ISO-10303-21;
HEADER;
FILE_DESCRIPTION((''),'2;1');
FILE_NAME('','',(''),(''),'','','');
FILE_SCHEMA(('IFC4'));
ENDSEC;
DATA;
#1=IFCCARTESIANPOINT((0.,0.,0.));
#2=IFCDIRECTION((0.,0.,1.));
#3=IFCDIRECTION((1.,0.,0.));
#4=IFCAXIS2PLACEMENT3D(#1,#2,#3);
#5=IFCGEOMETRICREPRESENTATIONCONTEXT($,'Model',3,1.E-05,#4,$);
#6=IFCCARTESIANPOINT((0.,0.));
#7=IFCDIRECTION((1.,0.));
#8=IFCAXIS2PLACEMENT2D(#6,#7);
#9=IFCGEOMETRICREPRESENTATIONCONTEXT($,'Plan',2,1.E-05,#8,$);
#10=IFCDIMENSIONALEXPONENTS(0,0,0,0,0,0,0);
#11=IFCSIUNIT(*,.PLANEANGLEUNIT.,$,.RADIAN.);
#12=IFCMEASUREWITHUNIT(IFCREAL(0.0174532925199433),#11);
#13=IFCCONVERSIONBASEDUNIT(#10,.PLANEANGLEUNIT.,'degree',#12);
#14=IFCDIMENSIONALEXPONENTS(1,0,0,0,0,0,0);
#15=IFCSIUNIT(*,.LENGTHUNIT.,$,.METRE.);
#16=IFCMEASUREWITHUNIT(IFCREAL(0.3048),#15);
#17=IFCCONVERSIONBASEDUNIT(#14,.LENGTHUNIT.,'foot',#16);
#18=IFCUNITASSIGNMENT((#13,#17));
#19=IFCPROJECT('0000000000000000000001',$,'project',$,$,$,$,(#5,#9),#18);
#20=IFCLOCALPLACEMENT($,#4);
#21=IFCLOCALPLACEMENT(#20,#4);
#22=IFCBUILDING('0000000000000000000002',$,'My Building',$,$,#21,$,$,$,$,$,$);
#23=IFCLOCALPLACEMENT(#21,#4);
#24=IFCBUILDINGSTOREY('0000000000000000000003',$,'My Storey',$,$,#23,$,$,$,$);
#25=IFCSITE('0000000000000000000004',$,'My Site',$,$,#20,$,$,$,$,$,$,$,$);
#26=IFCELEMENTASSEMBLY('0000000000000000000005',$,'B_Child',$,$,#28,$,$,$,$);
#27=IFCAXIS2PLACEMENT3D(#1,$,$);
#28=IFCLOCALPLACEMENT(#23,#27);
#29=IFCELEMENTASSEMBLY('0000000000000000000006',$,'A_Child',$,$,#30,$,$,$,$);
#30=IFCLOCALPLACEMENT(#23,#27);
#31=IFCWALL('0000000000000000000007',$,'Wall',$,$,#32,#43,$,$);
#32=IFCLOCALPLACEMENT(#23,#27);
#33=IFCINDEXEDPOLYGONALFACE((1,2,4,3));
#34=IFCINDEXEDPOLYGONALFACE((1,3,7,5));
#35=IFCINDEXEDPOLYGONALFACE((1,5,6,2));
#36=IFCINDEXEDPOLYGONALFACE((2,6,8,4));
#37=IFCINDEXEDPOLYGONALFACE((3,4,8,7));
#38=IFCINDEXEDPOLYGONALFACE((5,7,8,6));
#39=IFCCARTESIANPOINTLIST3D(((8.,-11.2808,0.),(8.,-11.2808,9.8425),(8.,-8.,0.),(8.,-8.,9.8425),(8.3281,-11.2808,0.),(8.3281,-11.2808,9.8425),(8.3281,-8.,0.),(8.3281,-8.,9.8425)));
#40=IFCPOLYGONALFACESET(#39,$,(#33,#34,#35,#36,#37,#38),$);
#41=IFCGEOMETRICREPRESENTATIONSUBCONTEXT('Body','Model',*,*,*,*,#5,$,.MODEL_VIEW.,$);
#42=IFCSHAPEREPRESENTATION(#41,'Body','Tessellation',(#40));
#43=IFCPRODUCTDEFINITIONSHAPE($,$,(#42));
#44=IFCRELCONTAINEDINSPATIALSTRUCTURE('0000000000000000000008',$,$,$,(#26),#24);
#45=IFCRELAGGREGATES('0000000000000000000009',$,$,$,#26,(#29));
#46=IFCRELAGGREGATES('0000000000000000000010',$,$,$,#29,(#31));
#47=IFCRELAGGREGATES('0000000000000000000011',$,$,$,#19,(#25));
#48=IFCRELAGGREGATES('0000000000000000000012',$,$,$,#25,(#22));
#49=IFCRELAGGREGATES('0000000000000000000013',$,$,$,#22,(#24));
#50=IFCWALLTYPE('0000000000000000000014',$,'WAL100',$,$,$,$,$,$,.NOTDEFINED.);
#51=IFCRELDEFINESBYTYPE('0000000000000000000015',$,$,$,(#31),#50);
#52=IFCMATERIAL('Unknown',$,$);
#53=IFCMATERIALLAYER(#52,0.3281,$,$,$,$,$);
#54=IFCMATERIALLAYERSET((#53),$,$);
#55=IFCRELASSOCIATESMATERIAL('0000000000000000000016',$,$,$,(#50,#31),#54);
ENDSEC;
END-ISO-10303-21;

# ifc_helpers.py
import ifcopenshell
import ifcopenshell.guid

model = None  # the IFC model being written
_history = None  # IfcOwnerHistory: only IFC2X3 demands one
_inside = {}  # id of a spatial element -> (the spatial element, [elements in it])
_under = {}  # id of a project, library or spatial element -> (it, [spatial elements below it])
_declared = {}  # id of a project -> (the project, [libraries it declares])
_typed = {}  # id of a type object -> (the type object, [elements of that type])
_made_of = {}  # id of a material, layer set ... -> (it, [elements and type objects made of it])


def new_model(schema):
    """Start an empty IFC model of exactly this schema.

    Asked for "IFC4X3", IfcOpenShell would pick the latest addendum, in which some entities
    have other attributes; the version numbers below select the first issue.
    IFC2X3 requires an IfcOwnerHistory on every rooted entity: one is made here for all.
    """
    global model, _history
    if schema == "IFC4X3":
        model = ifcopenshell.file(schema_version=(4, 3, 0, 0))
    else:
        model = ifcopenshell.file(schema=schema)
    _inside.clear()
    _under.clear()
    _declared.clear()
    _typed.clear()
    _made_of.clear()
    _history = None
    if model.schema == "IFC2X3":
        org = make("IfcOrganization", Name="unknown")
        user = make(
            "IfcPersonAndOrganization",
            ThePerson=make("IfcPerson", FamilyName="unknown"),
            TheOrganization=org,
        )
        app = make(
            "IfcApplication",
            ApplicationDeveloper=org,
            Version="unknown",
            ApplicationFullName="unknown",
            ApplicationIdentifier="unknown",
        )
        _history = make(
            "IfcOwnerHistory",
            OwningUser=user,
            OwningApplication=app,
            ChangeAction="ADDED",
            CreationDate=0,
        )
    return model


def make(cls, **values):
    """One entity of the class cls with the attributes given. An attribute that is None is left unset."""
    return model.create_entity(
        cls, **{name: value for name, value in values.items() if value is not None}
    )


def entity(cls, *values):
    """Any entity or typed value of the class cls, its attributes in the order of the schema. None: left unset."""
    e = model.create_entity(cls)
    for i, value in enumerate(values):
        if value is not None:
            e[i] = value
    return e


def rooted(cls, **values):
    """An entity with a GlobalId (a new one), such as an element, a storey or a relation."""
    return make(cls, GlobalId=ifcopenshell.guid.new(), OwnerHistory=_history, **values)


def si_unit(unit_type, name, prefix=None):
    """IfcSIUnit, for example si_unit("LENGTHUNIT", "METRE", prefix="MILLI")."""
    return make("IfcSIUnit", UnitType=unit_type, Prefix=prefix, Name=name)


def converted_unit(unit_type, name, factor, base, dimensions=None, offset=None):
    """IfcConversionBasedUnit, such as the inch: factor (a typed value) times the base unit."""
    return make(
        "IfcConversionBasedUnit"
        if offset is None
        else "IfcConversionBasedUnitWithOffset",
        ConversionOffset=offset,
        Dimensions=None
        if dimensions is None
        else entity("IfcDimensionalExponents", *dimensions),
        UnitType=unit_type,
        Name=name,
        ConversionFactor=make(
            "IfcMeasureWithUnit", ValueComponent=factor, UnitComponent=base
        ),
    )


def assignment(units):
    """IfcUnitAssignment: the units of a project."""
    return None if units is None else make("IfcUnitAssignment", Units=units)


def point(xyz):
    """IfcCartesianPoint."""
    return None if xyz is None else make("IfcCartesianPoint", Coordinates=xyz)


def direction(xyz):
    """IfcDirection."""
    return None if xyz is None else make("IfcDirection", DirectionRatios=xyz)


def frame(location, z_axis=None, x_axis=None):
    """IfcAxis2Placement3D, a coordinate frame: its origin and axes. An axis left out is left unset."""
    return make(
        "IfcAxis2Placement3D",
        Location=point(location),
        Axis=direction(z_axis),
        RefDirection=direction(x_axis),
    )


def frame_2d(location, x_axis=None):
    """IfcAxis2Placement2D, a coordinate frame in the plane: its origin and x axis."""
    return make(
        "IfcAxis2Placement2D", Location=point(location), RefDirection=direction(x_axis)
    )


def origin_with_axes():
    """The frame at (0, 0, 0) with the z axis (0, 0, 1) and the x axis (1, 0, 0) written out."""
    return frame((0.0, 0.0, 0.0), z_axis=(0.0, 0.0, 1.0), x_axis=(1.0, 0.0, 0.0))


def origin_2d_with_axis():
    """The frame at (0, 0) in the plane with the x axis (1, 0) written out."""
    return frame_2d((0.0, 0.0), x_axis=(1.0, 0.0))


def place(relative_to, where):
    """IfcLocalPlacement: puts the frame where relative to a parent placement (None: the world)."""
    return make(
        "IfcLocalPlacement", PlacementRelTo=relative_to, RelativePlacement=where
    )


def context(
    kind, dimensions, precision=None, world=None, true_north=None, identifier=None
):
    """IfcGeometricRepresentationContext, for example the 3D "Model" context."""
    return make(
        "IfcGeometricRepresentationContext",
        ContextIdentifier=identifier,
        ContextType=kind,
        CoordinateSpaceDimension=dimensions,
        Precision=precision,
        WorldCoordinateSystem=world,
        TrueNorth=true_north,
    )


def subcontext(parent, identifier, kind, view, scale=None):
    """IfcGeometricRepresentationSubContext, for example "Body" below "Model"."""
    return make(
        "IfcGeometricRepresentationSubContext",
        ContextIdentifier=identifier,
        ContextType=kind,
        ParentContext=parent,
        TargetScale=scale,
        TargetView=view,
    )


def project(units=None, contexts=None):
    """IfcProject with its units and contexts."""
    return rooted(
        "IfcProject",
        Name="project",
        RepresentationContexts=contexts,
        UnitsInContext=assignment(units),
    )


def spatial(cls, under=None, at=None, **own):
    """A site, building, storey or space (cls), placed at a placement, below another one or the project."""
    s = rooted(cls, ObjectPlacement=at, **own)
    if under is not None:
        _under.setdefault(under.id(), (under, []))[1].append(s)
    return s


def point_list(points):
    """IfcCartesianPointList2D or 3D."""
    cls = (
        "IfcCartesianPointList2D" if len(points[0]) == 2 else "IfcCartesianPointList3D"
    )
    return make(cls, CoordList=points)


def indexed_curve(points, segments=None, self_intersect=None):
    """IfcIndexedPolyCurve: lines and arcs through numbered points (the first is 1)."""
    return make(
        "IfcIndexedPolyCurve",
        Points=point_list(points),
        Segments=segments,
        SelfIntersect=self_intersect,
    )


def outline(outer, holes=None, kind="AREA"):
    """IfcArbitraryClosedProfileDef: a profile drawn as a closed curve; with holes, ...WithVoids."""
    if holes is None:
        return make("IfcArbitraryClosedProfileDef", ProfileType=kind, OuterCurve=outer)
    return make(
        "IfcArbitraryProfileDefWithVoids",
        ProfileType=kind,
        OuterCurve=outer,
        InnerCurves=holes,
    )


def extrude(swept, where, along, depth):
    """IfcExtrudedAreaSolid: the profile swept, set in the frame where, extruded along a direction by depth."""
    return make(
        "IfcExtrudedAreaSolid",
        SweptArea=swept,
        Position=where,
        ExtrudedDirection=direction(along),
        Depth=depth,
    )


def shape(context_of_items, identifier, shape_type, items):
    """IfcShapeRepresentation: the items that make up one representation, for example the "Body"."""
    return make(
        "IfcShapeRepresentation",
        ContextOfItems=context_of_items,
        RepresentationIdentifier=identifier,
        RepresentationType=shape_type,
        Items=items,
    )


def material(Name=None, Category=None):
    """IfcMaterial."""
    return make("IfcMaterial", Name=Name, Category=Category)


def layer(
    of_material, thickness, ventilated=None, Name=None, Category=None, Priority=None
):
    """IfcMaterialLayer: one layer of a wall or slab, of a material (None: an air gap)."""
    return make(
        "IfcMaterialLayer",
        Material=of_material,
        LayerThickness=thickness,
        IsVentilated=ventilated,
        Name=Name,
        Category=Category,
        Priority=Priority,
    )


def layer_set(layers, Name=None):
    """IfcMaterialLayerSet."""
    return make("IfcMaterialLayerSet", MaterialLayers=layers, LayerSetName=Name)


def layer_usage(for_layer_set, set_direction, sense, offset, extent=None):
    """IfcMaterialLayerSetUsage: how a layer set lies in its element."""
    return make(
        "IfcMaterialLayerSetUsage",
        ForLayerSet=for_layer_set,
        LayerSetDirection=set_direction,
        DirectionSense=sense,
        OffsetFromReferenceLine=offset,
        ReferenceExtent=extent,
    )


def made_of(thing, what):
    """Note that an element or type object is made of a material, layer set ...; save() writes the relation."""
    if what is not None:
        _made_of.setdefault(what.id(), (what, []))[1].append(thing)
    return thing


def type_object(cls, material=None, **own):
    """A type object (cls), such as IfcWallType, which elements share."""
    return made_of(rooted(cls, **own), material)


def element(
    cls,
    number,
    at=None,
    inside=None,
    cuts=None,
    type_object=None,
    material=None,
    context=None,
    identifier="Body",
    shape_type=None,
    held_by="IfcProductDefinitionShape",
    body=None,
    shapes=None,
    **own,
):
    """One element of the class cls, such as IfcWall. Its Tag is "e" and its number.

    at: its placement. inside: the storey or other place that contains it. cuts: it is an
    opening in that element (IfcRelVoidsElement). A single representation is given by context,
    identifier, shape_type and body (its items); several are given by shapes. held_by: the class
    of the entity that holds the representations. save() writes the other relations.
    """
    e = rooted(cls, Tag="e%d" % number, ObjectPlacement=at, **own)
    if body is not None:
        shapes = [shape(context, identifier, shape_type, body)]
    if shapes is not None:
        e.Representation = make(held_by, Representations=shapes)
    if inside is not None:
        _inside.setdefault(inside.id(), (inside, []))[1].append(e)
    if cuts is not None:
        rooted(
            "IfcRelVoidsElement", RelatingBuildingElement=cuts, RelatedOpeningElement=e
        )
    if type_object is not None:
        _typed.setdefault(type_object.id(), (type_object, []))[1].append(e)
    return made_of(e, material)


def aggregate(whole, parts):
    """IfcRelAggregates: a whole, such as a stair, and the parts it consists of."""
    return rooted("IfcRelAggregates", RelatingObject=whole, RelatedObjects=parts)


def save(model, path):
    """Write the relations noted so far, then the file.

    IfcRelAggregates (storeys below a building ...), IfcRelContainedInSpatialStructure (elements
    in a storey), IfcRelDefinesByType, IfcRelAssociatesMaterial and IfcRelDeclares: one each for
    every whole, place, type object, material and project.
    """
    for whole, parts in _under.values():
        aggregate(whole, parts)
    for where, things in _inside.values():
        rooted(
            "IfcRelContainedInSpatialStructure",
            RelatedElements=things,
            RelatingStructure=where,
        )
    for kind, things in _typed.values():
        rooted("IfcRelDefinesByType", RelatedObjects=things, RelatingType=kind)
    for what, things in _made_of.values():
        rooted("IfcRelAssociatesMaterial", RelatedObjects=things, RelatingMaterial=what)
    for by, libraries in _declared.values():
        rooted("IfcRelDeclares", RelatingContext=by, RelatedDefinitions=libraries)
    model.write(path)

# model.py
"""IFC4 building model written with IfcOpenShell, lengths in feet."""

from ifc_helpers import new_model, entity, si_unit, converted_unit, frame, origin_with_axes, origin_2d_with_axis, place, context, subcontext, project, spatial, indexed_curve, outline, extrude, material, layer, layer_set, layer_usage, type_object, element, aggregate, save


model = new_model("IFC4")

# Units and contexts
model_context = context("Model", 3, precision=1e-05, world=origin_with_axes())
plan_context = context("Plan", 2, precision=1e-05, world=origin_2d_with_axis())
body_context = subcontext(model_context, "Body", "Model", "MODEL_VIEW")
ifc_project = project(units=[converted_unit("PLANEANGLEUNIT", "degree", entity("IfcReal", 0.0174532925199433), si_unit("PLANEANGLEUNIT", "RADIAN"), dimensions=[0, 0, 0, 0, 0, 0, 0]), converted_unit("LENGTHUNIT", "foot", entity("IfcReal", 0.3048), si_unit("LENGTHUNIT", "METRE"), dimensions=[1, 0, 0, 0, 0, 0, 0])], contexts=[model_context, plan_context])

# Site, building, storey
site_placement = place(None, origin_with_axes())
site = spatial("IfcSite", under=ifc_project, at=site_placement, Name="My Site")
building_placement = place(site_placement, origin_with_axes())
building = spatial("IfcBuilding", under=site, at=building_placement, Name="My Building")
storey_placement = place(building_placement, origin_with_axes())
storey = spatial("IfcBuildingStorey", under=building, at=storey_placement, Name="My Storey")

# Shared definitions
ifc_material = material(Name="Unknown")
ifc_layer = layer(ifc_material, 0.3281)
ifc_layer_set = layer_set([ifc_layer])
wall_type = type_object("IfcWallType", Name="WAL100", PredefinedType="NOTDEFINED", material=ifc_layer_set)

# Element assemblies, wall
assembly_1_placement = place(storey_placement, frame((8.0, 0.0, 0.0), z_axis=(0.0, 0.0, 1.0), x_axis=(1.0, 0.0, 0.0)))
assembly_1 = element("IfcElementAssembly", 1, at=assembly_1_placement, inside=storey, Name="B_Child")
assembly_2_placement = place(assembly_1_placement, frame((0.0, -8.0, 0.0), z_axis=(0.0, 0.0, 1.0), x_axis=(1.0, 0.0, 0.0)))
assembly_2 = element("IfcElementAssembly", 2, at=assembly_2_placement, Name="A_Child")
aggregate(assembly_1, [assembly_2])
ifc_layer_usage_1 = layer_usage(ifc_layer_set, "AXIS2", "POSITIVE", 0.0)
wall_1_placement = place(assembly_2_placement, frame((0.0, 0.0, 0.0), z_axis=(0.0, 0.0, 1.0), x_axis=(0.0, -1.0, 0.0)))
wall_1 = element("IfcWall", 3, at=wall_1_placement, type_object=wall_type, material=ifc_layer_usage_1, Name="Wall", context=body_context, shape_type="SweptSolid", body=[
    extrude(outline(indexed_curve([(0.0, 0.0), (0.0, 0.3281), (3.2808, 0.3281), (3.2808, 0.0), (0.0, 0.0)], self_intersect=False)), origin_with_axes(), (0.0, 0.0, 1.0), 9.8425),
])
aggregate(assembly_2, [wall_1])

save(model, "model.ifc")
